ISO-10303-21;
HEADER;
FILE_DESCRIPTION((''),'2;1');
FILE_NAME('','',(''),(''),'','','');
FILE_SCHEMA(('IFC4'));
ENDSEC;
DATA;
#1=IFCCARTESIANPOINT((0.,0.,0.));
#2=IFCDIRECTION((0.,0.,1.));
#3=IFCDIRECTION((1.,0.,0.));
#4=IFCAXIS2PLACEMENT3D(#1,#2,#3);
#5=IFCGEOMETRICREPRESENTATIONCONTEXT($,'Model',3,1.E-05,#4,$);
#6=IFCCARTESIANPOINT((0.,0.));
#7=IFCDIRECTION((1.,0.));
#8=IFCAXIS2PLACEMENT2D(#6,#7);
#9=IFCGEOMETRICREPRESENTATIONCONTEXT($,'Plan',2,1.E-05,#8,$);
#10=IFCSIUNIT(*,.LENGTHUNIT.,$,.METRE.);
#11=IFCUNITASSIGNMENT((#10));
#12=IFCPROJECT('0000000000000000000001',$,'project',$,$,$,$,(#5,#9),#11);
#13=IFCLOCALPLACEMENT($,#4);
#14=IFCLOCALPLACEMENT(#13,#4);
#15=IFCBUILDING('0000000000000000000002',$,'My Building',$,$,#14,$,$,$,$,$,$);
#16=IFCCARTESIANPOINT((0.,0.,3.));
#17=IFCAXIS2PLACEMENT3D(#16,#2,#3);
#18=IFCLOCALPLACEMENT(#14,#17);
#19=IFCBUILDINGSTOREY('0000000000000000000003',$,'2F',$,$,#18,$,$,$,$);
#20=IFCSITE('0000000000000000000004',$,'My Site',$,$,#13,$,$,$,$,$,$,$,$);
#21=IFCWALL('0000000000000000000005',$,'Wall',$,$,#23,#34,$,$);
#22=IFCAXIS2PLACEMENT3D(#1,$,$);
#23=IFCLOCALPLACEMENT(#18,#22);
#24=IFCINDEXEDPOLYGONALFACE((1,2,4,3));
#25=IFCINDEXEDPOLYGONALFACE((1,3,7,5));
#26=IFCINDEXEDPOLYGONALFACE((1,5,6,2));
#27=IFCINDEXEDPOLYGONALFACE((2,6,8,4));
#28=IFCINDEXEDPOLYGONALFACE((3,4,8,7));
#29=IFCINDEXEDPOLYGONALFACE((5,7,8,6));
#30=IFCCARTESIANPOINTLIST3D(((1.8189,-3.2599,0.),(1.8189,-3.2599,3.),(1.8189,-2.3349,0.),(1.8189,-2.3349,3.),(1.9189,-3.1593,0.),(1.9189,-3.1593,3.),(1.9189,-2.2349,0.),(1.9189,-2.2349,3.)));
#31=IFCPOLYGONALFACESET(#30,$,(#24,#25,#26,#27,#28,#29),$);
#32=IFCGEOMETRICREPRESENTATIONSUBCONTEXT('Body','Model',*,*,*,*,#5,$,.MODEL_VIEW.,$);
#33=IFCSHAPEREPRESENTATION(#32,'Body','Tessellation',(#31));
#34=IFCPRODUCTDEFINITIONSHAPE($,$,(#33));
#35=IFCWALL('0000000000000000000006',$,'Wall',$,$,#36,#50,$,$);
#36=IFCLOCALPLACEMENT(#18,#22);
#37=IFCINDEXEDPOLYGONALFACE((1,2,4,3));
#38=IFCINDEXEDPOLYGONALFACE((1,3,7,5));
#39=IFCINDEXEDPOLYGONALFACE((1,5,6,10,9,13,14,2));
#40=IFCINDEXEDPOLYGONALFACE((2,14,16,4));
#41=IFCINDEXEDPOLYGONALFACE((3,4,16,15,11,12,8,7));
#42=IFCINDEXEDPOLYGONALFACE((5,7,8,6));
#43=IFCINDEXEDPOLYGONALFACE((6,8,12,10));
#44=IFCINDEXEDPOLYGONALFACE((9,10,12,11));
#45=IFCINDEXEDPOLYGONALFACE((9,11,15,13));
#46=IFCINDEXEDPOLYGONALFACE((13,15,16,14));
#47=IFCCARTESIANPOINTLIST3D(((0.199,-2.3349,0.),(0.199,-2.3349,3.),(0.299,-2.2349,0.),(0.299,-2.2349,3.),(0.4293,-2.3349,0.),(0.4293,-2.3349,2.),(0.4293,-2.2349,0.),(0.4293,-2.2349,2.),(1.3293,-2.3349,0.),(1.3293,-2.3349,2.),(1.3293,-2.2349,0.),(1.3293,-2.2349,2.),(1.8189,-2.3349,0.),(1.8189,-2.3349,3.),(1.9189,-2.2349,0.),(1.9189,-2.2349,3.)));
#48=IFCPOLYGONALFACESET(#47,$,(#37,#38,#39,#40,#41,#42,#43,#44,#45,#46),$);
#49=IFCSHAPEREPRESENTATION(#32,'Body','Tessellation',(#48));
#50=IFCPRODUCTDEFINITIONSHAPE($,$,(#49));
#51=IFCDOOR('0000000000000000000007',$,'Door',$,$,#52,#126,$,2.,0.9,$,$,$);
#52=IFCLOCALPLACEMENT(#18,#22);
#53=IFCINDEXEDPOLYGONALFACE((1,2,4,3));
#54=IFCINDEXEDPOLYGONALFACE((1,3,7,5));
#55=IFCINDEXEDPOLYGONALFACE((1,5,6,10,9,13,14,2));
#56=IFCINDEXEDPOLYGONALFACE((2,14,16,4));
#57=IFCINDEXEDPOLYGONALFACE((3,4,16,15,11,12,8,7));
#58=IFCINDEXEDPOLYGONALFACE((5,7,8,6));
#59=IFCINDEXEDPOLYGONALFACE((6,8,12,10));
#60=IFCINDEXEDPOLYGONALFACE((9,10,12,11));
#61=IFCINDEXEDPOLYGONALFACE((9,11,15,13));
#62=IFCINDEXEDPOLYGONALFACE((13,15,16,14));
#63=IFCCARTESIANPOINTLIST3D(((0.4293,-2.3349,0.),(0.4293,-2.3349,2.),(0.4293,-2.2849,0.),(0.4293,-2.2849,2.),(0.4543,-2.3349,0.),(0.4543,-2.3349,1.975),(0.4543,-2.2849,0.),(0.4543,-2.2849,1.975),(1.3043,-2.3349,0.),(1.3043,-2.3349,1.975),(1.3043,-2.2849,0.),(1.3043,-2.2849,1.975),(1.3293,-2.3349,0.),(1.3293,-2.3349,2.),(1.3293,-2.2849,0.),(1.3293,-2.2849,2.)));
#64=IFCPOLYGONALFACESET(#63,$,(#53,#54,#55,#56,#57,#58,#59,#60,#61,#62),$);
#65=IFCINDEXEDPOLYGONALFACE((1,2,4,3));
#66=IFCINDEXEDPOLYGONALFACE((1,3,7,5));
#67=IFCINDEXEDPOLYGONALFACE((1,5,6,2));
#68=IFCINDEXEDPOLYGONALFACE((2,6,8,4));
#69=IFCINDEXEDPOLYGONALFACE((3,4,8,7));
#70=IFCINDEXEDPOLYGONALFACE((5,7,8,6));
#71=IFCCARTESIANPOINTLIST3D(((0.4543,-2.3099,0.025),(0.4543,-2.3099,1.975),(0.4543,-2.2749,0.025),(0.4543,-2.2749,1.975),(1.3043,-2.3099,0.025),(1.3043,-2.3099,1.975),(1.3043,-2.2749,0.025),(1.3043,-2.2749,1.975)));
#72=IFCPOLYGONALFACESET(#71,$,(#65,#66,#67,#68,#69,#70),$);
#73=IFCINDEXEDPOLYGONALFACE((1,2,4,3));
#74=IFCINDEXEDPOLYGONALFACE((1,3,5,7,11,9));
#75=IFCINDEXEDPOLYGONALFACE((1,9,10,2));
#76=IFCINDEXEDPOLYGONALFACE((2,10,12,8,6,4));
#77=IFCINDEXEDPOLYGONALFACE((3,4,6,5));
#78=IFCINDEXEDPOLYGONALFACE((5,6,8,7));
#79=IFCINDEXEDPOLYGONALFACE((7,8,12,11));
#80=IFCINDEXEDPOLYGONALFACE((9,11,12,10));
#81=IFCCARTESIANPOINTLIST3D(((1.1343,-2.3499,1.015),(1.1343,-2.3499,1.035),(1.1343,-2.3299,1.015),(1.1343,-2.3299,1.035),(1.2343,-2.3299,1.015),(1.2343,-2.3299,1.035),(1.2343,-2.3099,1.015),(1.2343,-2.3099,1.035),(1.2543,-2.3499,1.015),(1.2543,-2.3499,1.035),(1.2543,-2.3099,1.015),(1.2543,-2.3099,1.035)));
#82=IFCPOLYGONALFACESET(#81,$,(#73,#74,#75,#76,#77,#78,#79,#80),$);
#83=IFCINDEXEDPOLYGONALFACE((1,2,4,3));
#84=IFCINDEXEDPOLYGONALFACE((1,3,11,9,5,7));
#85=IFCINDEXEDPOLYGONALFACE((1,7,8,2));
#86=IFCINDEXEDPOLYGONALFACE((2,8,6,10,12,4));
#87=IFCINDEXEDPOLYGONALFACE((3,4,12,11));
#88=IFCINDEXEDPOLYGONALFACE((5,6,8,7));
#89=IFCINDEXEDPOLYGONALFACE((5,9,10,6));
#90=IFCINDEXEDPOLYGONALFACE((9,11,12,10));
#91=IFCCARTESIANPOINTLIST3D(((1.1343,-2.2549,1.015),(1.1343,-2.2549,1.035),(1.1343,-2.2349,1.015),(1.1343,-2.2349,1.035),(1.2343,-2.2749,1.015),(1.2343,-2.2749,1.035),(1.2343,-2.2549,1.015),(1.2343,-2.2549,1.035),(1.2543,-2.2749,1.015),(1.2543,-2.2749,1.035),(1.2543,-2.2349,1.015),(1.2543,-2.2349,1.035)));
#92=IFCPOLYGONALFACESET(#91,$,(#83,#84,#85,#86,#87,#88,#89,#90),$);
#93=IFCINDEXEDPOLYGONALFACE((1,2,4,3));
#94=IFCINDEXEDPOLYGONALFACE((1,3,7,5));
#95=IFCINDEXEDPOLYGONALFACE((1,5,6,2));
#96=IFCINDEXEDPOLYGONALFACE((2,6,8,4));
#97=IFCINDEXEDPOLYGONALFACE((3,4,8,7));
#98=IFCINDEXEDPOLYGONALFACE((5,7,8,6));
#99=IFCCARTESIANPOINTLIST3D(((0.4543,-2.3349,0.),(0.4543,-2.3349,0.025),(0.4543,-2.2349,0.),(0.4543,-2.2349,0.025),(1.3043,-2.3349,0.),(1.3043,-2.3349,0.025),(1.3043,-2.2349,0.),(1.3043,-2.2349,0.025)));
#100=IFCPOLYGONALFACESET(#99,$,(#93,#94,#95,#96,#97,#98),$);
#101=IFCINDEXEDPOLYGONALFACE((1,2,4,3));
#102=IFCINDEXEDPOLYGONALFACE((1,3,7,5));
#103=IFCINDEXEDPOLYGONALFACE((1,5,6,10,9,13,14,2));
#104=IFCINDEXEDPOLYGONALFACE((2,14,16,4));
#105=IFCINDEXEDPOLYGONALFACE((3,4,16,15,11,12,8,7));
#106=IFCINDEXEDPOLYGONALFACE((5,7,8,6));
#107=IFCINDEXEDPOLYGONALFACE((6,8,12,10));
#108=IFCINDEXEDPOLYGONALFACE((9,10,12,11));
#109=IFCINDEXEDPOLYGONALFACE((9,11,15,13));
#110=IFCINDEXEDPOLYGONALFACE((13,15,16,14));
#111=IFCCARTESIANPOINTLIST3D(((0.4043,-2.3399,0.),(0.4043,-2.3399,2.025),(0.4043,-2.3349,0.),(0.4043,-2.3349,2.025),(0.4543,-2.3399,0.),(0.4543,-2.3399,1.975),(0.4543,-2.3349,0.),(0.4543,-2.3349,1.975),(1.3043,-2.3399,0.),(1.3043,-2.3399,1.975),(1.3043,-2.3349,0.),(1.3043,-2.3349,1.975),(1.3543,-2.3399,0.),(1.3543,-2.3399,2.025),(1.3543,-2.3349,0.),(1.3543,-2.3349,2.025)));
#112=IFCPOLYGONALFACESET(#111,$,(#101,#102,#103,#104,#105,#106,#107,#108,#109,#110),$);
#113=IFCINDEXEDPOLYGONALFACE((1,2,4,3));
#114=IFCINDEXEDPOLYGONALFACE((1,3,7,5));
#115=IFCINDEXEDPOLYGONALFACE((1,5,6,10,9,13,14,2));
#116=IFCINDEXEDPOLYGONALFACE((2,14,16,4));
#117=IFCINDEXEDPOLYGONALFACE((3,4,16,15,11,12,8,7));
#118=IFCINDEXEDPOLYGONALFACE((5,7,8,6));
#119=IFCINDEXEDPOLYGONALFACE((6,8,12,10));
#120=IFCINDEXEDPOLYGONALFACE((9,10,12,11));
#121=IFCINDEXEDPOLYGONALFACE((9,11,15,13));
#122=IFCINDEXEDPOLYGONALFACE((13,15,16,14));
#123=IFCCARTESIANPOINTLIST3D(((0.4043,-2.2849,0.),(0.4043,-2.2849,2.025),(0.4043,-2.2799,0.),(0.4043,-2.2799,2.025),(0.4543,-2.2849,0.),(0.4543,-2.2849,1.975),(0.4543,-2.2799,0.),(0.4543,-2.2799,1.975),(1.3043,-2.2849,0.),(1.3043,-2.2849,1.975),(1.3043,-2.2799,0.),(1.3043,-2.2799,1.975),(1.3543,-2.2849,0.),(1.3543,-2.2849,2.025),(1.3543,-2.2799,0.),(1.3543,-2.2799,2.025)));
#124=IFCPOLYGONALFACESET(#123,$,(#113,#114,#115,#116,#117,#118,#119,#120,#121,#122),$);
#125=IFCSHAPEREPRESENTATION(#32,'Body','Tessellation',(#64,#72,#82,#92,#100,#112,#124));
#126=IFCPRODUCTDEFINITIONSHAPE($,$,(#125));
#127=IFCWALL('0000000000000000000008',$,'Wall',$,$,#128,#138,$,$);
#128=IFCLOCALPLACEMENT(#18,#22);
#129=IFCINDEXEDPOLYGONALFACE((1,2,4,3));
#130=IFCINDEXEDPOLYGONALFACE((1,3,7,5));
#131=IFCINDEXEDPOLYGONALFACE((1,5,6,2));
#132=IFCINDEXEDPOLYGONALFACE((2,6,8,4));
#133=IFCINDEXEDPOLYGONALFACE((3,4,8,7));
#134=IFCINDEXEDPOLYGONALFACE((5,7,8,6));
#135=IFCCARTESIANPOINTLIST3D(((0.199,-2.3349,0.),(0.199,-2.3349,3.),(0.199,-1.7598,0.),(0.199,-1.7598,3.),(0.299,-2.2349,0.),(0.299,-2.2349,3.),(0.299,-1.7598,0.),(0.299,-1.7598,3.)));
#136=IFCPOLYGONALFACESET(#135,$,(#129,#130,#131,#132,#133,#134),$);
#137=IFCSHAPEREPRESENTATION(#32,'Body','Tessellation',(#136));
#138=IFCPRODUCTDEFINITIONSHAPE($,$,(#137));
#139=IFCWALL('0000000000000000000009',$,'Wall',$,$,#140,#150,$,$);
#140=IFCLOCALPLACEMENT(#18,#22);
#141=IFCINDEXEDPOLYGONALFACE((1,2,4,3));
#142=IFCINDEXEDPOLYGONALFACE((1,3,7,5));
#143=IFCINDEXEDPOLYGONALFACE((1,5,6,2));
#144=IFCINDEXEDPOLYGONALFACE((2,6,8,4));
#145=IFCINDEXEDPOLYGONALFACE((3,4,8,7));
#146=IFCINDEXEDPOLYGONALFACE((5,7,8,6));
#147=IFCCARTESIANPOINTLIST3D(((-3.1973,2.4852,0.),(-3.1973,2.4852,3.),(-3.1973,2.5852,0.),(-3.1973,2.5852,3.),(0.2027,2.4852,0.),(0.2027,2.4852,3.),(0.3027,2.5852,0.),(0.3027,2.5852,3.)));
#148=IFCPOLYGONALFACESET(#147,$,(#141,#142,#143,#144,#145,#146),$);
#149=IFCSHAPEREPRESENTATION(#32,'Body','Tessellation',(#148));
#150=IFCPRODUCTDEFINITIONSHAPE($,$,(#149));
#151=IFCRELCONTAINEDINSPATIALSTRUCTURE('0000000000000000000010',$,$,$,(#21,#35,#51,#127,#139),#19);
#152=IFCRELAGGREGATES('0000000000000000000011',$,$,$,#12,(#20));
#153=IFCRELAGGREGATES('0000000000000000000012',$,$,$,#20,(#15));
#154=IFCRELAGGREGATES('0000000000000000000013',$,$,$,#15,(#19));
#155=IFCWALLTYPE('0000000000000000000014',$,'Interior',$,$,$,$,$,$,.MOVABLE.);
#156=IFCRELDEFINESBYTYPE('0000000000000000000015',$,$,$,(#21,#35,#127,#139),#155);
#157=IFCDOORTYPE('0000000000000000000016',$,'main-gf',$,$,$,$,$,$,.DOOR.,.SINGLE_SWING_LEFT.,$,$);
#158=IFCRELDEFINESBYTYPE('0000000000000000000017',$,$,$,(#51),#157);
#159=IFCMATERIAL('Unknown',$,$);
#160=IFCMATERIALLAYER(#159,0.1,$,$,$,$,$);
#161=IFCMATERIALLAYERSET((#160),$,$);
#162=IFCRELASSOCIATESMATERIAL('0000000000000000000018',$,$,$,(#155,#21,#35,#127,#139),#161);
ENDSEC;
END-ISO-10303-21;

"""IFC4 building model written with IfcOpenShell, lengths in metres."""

from ifc_helpers import new_model, entity, si_unit, frame, origin_with_axes, origin_2d_with_axis, place, context, subcontext, project, spatial, line, indexed_curve, outline, extrude, shape, source, transform, mapped, material, layer, layer_set, layer_usage, type_object, type_shapes, element, fill, save


model = new_model("IFC4")

# Units and contexts
model_context = context("Model", 3, precision=1e-05, world=origin_with_axes())
plan_context = context("Plan", 2, precision=1e-05, world=origin_2d_with_axis())
body_context_1 = subcontext(model_context, "Body", "Model", "MODEL_VIEW")
body_context_2 = subcontext(plan_context, "Body", "Plan", "PLAN_VIEW")
ifc_project = project(units=[si_unit("LENGTHUNIT", "METRE")], contexts=[model_context, plan_context])

# Site, building, storey
site_placement = place(None, origin_with_axes())
site = spatial("IfcSite", under=ifc_project, at=site_placement, Name="My Site")
building_placement = place(site_placement, origin_with_axes())
building = spatial("IfcBuilding", under=site, at=building_placement, Name="My Building")
storey_placement = place(building_placement, frame((0.0, 0.0, 3.0), z_axis=(0.0, 0.0, 1.0), x_axis=(1.0, 0.0, 0.0)))
storey = spatial("IfcBuildingStorey", under=building, at=storey_placement, Name="2F")

# Shared definitions
ifc_material = material(Name="Unknown")

# Wall
ifc_layer_1 = layer(ifc_material, 0.1)
ifc_layer_set_1 = layer_set([ifc_layer_1])
wall_type = type_object("IfcWallType", Name="Interior", PredefinedType="MOVABLE", material=ifc_layer_set_1)
ifc_layer_usage_1 = layer_usage(ifc_layer_set_1, "AXIS2", "POSITIVE", 0.0)
wall_1_placement = place(storey_placement, frame((1.9189, -3.2593, 0.0), z_axis=(0.0, 0.0, 1.0), x_axis=(0.0, 1.0, 0.0)))
element("IfcWall", 1, at=wall_1_placement, inside=storey, type_object=wall_type, material=ifc_layer_usage_1, Name="Wall", context=body_context_1, shape_type="SweptSolid", body=[
    extrude(outline(indexed_curve([(0.1, 0.0), (-0.0006, 0.1), (0.9244, 0.1), (1.0244, 0.0)], segments=[line(1, 2, 3, 4, 1)])), origin_with_axes(), (0.0, 0.0, 1.0), 3.0),
])

# Wall, opening, door
ifc_layer_usage_2 = layer_usage(ifc_layer_set_1, "AXIS2", "POSITIVE", 0.0)
wall_2_placement = place(storey_placement, frame((1.9189, -2.2349, 0.0), z_axis=(0.0, 0.0, 1.0), x_axis=(-1.0, 0.0, 0.0)))
wall_2 = element("IfcWall", 2, at=wall_2_placement, inside=storey, type_object=wall_type, material=ifc_layer_usage_2, Name="Wall", context=body_context_1, shape_type="SweptSolid", body=[
    extrude(outline(indexed_curve([(0.0, 0.0), (0.1, 0.1), (1.7199, 0.1), (1.6199, 0.0)], segments=[line(1, 2, 3, 4, 1)])), origin_with_axes(), (0.0, 0.0, 1.0), 3.0),
])
shared_shape_1 = source(origin_with_axes(), body_context_1, "Body", "SweptSolid", [
    extrude(outline(indexed_curve([(0.0, 0.0), (0.9, 0.0), (0.9, 2.0), (0.0, 2.0)], segments=[line(1, 2, 3, 4, 1)])), frame((0.0, -0.6, 0.0), z_axis=(0.0, -1.0, 0.0), x_axis=(1.0, 0.0, 0.0)), (0.0, 0.0, -1.0), 1.2),
])
opening_1_placement = place(wall_2_placement, frame((1.4896, 0.1, 0.0), z_axis=(0.0, 0.0, 1.0), x_axis=(-1.0, 0.0, 0.0)))
opening_1 = element("IfcOpeningElement", 3, at=opening_1_placement, cuts=wall_2, PredefinedType="OPENING", context=body_context_1, shape_type="MappedRepresentation", body=[
    mapped(shared_shape_1, transform((0.0, 0.0, 0.0), x_axis=(1.0, 0.0, 0.0), y_axis=(0.0, 1.0, 0.0), z_axis=(0.0, 0.0, 1.0), scale=1.0)),
])
door_type = type_object("IfcDoorType", Name="main-gf", OperationType="SINGLE_SWING_LEFT", PredefinedType="DOOR")
shared_shape_2 = source(origin_with_axes(), body_context_1, "Body", "SweptSolid", [
    extrude(outline(indexed_curve([(0.0, 0.0), (0.0, 2.0), (0.9, 2.0), (0.9, 0.0), (0.875, 0.0), (0.875, 1.975), (0.025, 1.975), (0.025, 0.0)], segments=[line(1, 2, 3, 4, 5, 6, 7, 8, 1)])), frame((0.0, 0.0, 0.0), z_axis=(0.0, -1.0, 0.0), x_axis=(1.0, 0.0, 0.0)), (0.0, 0.0, -1.0), 0.05),
    extrude(outline(indexed_curve([(0.0, 0.0), (0.85, 0.0), (0.85, 0.035), (0.0, 0.035)], segments=[line(1, 2, 3, 4, 1)])), frame((0.025, 0.025, 0.025), z_axis=(0.0, 0.0, 1.0), x_axis=(1.0, 0.0, 0.0)), (0.0, 0.0, 1.0), 1.95),
    extrude(outline(indexed_curve([(0.0, 0.0), (0.0, -0.04), (-0.12, -0.04), (-0.12, -0.02), (-0.02, -0.02), (-0.02, 0.0)], segments=[line(1, 2, 3, 4, 5, 6, 1)])), frame((0.825, 0.025, 1.015), z_axis=(0.0, 0.0, 1.0), x_axis=(1.0, 0.0, 0.0)), (0.0, 0.0, 1.0), 0.02),
    extrude(outline(indexed_curve([(0.0, 0.0), (0.0, 0.04), (-0.12, 0.04), (-0.12, 0.02), (-0.02, 0.02), (-0.02, 0.0)], segments=[line(1, 2, 3, 4, 5, 6, 1)])), frame((0.825, 0.06, 1.015), z_axis=(0.0, 0.0, 1.0), x_axis=(1.0, 0.0, 0.0)), (0.0, 0.0, 1.0), 0.02),
    extrude(outline(indexed_curve([(0.0, 0.0), (0.85, 0.0), (0.85, 0.1), (0.0, 0.1)], segments=[line(1, 2, 3, 4, 1)])), frame((0.025, 0.0, 0.0), z_axis=(0.0, 0.0, 1.0), x_axis=(1.0, 0.0, 0.0)), (0.0, 0.0, 1.0), 0.025),
    extrude(outline(indexed_curve([(0.0, 0.0), (0.0, 2.025), (0.95, 2.025), (0.95, 0.0), (0.9, 0.0), (0.9, 1.975), (0.05, 1.975), (0.05, 0.0)], segments=[line(1, 2, 3, 4, 5, 6, 7, 8, 1)])), frame((-0.025, -0.005, 0.0), z_axis=(0.0, -1.0, 0.0), x_axis=(1.0, 0.0, 0.0)), (0.0, 0.0, -1.0), 0.005),
    extrude(outline(indexed_curve([(0.0, 0.0), (0.0, 2.025), (0.95, 2.025), (0.95, 0.0), (0.9, 0.0), (0.9, 1.975), (0.05, 1.975), (0.05, 0.0)], segments=[line(1, 2, 3, 4, 5, 6, 7, 8, 1)])), frame((-0.025, 0.05, 0.0), z_axis=(0.0, -1.0, 0.0), x_axis=(1.0, 0.0, 0.0)), (0.0, 0.0, -1.0), 0.005),
])
shared_shape_3 = source(origin_with_axes(), body_context_2, "Body", "Curve2D", [
    entity("IfcIndexedPolyCurve", entity("IfcCartesianPointList2D", [[0.0, 0.0], [0.025, 0.0], [0.025, 0.05], [0.0, 0.05]]), [entity("IfcLineIndex", [1, 2, 3, 4, 1])]),
    entity("IfcIndexedPolyCurve", entity("IfcCartesianPointList2D", [[0.9, 0.0], [0.875, 0.0], [0.875, 0.05], [0.9, 0.05]]), [entity("IfcLineIndex", [1, 2, 3, 4, 1])]),
    entity("IfcIndexedPolyCurve", entity("IfcCartesianPointList2D", [[0.025, 0.05], [0.025, -0.8], [0.06, -0.8]])),
    entity("IfcTrimmedCurve", entity("IfcEllipse", entity("IfcAxis2Placement2D", entity("IfcCartesianPoint", [0.06, 0.05]), entity("IfcDirection", [1.0, 0.0])), 0.815, 0.85), [entity("IfcCartesianPoint", [0.06, -0.8])], [entity("IfcCartesianPoint", [0.06, 0.9])], True, "CARTESIAN"),
    entity("IfcIndexedPolyCurve", entity("IfcCartesianPointList2D", [[0.025, 0.05], [0.06, 0.05], [0.06, 0.9], [0.025, 0.9]]), [entity("IfcLineIndex", [1, 2, 3, 4, 1])]),
])
type_shapes(door_type, [shared_shape_2, shared_shape_3])
door_1_placement = place(opening_1_placement, frame((0.0, 0.0, 0.0), z_axis=(0.0, 0.0, 1.0), x_axis=(1.0, 0.0, 0.0)))
door_1 = element("IfcDoor", 4, at=door_1_placement, inside=storey, type_object=door_type, Name="Door", OverallHeight=2.0, OverallWidth=0.9, shapes=[
    shape(body_context_1, "Body", "MappedRepresentation", [mapped(shared_shape_2, transform((0.0, 0.0, 0.0), x_axis=(1.0, 0.0, 0.0), y_axis=(0.0, 1.0, 0.0), z_axis=(0.0, 0.0, 1.0), scale=1.0))]),
    shape(body_context_2, "Body", "MappedRepresentation", [mapped(shared_shape_3, transform((0.0, 0.0, 0.0), x_axis=(1.0, 0.0, 0.0), y_axis=(0.0, 1.0, 0.0), z_axis=(0.0, 0.0, 1.0), scale=1.0))]),
])
fill(opening_1, door_1)

# Walls
ifc_layer_usage_3 = layer_usage(ifc_layer_set_1, "AXIS2", "POSITIVE", 0.0)
wall_3_placement = place(storey_placement, frame((0.199, -1.7598, 0.0), z_axis=(0.0, 0.0, 1.0), x_axis=(0.0, -1.0, 0.0)))
element("IfcWall", 5, at=wall_3_placement, inside=storey, type_object=wall_type, material=ifc_layer_usage_3, Name="Wall", context=body_context_1, shape_type="SweptSolid", body=[
    extrude(outline(indexed_curve([(0.0, 0.0), (0.0, 0.1), (0.4751, 0.1), (0.5751, 0.0)], segments=[line(1, 2, 3, 4, 1)])), origin_with_axes(), (0.0, 0.0, 1.0), 3.0),
])
ifc_layer_usage_4 = layer_usage(ifc_layer_set_1, "AXIS2", "POSITIVE", 0.0)
wall_4_placement = place(storey_placement, frame((-3.1973, 2.4852, 0.0), z_axis=(0.0, 0.0, 1.0), x_axis=(1.0, 0.0, 0.0)))
element("IfcWall", 6, at=wall_4_placement, inside=storey, type_object=wall_type, material=ifc_layer_usage_4, Name="Wall", context=body_context_1, shape_type="SweptSolid", body=[
    extrude(outline(indexed_curve([(0.0, 0.0), (0.0, 0.1), (3.5, 0.1), (3.4, 0.0)], segments=[line(1, 2, 3, 4, 1)])), origin_with_axes(), (0.0, 0.0, 1.0), 3.0),
])

save(model, "model.ifc")
